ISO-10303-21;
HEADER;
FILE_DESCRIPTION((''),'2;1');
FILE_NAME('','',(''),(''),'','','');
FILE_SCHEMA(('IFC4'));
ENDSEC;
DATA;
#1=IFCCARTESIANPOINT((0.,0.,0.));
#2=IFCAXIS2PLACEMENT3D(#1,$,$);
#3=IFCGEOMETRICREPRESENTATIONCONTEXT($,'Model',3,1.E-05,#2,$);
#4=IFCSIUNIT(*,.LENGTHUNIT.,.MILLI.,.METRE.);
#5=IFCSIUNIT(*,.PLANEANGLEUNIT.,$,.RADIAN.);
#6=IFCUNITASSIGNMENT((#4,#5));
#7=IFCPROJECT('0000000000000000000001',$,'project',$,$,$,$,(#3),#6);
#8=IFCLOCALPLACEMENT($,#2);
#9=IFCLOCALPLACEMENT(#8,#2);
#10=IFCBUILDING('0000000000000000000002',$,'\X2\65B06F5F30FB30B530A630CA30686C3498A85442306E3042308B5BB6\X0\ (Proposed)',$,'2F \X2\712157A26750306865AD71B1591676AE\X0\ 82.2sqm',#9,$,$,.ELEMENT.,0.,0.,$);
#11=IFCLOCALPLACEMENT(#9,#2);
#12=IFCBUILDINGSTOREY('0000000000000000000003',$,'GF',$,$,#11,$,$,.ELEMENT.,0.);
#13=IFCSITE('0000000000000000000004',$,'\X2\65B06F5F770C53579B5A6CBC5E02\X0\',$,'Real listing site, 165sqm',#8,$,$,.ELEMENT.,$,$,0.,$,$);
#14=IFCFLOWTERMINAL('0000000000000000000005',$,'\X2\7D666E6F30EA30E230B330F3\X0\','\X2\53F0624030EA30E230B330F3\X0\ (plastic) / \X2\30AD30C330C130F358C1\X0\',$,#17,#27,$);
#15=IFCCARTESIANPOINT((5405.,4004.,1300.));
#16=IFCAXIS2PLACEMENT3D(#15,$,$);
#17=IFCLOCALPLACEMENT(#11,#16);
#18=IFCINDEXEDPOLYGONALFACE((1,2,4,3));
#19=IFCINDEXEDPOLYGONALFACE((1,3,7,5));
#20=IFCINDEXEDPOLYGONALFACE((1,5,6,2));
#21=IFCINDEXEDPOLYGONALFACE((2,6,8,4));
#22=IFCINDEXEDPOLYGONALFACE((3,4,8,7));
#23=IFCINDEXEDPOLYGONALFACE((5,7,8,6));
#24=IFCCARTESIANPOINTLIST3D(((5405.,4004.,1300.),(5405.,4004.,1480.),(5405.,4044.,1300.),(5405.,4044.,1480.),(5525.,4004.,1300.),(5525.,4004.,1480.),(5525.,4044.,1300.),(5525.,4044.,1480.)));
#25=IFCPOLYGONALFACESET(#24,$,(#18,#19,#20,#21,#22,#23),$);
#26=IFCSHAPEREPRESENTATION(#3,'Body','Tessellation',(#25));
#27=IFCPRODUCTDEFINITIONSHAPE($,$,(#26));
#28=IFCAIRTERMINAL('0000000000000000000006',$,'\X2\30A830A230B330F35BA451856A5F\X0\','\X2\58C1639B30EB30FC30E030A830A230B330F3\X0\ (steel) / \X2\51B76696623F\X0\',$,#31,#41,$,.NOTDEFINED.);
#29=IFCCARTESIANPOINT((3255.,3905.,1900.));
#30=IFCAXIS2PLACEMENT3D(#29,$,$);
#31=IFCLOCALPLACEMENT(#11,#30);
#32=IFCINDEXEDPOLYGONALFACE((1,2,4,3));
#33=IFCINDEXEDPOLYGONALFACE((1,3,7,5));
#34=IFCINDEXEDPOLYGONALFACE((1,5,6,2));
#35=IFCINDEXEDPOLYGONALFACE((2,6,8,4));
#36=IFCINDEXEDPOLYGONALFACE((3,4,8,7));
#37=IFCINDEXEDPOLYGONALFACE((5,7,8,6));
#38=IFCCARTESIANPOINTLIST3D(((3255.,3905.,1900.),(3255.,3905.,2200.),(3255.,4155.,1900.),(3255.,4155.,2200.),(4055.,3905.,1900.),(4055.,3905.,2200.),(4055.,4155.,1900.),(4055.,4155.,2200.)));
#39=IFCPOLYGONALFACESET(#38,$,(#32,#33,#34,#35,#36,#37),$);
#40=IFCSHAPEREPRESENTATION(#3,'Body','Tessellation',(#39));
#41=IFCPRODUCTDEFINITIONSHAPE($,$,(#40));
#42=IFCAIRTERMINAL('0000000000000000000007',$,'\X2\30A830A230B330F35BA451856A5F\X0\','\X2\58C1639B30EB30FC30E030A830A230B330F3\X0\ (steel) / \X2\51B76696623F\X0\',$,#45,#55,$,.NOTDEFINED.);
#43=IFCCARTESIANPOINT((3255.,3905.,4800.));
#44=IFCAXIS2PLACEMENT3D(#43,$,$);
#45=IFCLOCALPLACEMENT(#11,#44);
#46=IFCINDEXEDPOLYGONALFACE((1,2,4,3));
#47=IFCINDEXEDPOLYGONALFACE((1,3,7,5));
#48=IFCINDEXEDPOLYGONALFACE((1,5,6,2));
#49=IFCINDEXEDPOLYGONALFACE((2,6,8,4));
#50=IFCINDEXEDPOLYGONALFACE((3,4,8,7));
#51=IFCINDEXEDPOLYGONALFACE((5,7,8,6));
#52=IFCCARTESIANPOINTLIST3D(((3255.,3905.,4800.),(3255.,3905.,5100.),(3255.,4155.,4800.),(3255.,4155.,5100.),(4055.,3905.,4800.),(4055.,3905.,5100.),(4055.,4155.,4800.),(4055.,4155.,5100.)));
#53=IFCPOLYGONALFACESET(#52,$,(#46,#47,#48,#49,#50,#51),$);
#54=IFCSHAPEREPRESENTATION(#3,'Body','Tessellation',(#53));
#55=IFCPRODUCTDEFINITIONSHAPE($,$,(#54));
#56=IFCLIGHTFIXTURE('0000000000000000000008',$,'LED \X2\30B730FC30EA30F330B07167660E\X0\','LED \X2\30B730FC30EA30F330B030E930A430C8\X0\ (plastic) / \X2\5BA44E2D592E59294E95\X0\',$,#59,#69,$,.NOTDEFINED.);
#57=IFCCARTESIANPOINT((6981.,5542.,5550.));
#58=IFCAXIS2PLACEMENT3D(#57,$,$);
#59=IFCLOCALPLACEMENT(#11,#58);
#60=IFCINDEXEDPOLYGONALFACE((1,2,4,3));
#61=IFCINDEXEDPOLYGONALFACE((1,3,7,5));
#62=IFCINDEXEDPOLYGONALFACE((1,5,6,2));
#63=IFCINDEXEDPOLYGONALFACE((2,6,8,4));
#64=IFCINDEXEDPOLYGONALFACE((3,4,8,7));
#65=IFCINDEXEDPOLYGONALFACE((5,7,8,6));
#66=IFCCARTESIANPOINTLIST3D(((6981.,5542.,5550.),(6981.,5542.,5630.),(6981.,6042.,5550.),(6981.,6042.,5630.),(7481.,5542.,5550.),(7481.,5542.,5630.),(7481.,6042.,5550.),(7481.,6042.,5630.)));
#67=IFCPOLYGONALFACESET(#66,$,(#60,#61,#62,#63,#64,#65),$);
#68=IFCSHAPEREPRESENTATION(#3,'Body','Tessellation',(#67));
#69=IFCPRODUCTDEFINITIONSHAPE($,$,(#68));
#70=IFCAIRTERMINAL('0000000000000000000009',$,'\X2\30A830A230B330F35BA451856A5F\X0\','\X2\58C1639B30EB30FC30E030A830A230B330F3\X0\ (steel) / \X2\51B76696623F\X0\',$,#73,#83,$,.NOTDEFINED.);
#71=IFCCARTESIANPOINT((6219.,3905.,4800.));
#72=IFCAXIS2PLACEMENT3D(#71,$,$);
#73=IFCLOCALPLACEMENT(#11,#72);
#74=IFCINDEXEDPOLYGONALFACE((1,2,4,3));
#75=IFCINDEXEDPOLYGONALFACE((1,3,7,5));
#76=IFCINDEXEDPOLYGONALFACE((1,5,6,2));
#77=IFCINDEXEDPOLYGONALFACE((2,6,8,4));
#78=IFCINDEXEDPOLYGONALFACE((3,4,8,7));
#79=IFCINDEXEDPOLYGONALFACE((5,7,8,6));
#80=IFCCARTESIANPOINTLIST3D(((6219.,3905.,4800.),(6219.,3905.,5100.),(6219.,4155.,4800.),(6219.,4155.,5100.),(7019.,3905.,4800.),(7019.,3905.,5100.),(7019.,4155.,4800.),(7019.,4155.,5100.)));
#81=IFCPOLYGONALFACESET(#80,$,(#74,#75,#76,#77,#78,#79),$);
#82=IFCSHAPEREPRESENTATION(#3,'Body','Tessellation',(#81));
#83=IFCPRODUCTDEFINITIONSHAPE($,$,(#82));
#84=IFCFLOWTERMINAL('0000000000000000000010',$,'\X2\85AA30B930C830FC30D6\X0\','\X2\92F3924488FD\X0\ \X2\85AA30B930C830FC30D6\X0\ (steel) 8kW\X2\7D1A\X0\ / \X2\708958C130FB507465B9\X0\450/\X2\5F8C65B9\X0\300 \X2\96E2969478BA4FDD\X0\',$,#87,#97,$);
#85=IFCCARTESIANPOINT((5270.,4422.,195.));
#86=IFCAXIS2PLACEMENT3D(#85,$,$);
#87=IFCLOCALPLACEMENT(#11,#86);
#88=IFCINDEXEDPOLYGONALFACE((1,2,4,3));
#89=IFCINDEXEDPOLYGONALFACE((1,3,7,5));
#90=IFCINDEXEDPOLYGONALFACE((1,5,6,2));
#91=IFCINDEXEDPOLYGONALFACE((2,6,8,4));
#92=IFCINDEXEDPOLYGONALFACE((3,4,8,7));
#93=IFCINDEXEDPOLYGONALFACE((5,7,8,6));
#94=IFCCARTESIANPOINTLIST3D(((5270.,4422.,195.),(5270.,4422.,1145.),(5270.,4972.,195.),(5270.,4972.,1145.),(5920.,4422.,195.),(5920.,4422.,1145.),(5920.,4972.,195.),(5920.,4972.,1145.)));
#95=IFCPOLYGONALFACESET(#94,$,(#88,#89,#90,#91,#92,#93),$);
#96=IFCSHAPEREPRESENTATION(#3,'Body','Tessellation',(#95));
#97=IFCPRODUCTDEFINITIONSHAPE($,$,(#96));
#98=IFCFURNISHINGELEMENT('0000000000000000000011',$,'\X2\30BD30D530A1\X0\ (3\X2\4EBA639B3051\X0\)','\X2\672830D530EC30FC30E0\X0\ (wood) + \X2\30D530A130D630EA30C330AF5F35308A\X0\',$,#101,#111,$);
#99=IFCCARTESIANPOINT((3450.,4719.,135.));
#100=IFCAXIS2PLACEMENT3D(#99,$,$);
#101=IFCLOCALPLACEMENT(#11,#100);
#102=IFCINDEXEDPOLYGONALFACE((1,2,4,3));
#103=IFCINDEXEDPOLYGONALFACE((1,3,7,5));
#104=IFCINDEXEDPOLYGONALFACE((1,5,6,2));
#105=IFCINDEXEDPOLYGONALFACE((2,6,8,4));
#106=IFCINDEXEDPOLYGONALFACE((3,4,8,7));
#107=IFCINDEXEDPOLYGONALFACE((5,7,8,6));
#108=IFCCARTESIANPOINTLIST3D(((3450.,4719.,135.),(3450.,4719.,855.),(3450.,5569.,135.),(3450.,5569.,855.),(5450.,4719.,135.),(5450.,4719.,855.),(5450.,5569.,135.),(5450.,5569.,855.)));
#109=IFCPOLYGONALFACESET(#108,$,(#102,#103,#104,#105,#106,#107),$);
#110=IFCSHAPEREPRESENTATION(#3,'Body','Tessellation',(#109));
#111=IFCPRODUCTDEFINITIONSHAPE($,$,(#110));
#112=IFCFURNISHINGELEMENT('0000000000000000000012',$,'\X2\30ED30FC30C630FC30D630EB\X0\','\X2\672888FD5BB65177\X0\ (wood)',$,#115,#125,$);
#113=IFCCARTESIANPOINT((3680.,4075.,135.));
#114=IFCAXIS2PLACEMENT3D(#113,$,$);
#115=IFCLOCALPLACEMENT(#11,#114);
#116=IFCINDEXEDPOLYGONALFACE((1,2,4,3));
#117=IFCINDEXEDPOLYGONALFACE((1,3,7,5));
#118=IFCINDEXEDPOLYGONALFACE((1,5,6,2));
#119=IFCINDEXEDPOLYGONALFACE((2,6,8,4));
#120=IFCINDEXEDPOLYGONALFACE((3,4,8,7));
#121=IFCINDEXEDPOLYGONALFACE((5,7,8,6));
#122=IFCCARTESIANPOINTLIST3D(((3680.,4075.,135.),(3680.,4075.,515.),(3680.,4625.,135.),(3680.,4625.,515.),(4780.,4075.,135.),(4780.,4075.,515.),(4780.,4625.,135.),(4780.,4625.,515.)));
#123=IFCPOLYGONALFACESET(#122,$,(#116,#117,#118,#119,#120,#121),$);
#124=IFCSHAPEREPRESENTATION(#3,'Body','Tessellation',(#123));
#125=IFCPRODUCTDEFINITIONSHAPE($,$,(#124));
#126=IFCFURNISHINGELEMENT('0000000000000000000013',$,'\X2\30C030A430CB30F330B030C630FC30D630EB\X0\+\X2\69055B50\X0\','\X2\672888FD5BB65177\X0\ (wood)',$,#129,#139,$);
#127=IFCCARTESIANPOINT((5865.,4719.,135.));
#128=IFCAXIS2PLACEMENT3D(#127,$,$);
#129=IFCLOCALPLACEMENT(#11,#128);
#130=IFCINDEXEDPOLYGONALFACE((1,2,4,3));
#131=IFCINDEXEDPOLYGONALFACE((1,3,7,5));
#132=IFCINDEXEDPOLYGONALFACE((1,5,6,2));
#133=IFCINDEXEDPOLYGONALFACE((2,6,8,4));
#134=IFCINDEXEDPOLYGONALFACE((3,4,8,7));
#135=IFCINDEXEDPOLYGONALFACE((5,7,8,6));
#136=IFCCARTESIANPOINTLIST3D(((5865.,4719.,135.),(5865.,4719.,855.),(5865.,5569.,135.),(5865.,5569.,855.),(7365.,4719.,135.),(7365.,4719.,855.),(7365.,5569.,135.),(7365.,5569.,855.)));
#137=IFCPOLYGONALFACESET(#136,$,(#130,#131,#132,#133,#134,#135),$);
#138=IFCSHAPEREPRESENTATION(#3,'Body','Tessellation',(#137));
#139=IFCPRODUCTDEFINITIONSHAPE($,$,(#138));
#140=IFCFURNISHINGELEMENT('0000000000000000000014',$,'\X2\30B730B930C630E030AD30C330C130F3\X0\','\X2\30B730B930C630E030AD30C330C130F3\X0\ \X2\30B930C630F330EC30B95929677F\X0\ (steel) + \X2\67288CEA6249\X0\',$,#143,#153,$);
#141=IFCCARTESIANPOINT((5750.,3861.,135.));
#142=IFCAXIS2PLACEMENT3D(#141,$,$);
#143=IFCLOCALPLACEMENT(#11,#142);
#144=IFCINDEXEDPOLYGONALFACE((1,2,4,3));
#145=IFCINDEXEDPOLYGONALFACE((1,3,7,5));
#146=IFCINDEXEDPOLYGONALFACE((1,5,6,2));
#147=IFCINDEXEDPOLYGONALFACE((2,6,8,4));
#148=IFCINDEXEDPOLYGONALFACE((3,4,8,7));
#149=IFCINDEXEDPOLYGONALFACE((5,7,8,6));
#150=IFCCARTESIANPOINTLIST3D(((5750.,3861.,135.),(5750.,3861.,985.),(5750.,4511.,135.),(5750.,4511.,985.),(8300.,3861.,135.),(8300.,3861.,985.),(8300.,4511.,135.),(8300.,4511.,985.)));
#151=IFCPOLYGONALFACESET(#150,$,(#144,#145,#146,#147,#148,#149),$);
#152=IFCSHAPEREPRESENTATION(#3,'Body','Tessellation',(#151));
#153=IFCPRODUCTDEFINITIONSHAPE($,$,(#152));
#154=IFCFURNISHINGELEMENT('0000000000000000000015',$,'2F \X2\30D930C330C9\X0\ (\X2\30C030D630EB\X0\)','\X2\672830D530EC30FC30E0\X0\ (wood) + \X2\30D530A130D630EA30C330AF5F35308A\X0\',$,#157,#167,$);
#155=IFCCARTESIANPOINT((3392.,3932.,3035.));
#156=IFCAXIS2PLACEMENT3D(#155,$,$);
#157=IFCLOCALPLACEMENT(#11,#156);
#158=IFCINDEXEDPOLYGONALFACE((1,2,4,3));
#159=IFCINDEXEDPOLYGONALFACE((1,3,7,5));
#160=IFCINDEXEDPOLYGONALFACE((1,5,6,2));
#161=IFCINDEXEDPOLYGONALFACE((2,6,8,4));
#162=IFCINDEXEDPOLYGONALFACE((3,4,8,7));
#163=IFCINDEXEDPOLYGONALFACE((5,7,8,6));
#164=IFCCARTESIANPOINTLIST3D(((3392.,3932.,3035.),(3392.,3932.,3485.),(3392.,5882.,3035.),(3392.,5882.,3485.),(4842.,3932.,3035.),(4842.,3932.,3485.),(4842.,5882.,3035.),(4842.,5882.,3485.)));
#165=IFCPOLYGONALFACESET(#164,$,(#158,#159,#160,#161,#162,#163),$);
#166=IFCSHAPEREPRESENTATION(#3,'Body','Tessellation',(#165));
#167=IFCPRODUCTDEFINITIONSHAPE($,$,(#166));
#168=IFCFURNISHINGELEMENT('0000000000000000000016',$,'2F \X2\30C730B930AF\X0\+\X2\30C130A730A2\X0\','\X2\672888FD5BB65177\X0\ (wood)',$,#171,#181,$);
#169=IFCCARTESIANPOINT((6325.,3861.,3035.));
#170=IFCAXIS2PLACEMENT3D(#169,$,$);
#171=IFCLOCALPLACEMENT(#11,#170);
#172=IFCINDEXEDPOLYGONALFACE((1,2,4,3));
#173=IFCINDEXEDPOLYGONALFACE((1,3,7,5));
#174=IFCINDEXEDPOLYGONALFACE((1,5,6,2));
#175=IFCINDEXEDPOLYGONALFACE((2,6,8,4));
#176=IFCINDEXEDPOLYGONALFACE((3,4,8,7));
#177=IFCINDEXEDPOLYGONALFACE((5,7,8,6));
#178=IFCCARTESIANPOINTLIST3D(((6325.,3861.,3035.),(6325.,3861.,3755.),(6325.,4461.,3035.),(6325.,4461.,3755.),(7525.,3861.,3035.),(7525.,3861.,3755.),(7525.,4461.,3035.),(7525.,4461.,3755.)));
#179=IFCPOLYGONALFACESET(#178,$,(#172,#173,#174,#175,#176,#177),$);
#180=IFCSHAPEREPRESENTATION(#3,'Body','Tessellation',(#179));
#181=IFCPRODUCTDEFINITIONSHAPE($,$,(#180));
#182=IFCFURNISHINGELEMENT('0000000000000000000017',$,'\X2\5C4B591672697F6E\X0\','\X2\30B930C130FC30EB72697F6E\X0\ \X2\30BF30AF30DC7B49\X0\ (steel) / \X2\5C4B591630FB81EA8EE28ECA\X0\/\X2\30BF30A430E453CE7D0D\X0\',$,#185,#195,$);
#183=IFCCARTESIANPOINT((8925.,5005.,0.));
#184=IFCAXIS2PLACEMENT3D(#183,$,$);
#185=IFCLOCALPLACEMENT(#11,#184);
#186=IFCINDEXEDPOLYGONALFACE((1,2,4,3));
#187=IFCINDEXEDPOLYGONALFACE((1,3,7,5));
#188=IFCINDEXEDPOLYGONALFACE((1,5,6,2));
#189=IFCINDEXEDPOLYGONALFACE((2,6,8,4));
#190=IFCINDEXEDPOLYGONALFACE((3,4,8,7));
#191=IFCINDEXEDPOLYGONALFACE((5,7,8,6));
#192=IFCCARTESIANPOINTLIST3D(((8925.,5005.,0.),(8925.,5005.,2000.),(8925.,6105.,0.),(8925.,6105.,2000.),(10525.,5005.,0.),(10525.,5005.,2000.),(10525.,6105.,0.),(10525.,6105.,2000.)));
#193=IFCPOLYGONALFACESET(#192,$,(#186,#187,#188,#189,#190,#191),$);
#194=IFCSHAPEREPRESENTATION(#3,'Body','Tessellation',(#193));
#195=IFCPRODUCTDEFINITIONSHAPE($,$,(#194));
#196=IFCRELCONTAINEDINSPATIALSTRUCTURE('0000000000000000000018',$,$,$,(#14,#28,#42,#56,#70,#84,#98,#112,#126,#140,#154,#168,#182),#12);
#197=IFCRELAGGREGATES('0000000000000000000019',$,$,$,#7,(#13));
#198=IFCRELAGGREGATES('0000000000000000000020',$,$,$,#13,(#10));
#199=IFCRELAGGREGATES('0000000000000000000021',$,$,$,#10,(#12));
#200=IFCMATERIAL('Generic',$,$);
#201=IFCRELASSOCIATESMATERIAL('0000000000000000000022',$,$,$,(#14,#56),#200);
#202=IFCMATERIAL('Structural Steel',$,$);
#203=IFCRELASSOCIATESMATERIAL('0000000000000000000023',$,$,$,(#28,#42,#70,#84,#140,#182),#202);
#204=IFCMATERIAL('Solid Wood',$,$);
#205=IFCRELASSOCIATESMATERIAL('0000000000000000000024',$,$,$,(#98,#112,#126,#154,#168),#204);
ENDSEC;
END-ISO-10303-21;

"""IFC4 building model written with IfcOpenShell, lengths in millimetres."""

from ifc_helpers import new_model, si_unit, frame, frame_2d, origin, place, context, project, spatial, rectangle, extrude, material, element, save


model = new_model("IFC4")

# Units and contexts
model_context = context("Model", 3, precision=1e-05, world=origin())
ifc_project = project(units=[si_unit("LENGTHUNIT", "METRE", prefix="MILLI"), si_unit("PLANEANGLEUNIT", "RADIAN")], contexts=[model_context])

# Site, building, storey
site_placement = place(None, origin())
site = spatial("IfcSite", under=ifc_project, at=site_placement, Name="新潟県南魚沼市", ObjectType="Real listing site, 165sqm", CompositionType="ELEMENT", RefElevation=0.0)
building_placement = place(site_placement, origin())
building = spatial("IfcBuilding", under=site, at=building_placement, Name="新潟・サウナと水風呂のある家 (Proposed)", ObjectType="2F 無垢材と断熱外皮 82.2sqm", CompositionType="ELEMENT", ElevationOfRefHeight=0.0, ElevationOfTerrain=0.0)
storey_placement = place(building_placement, origin())
storey = spatial("IfcBuildingStorey", under=building, at=storey_placement, Name="GF", CompositionType="ELEMENT", Elevation=0.0)

# Shared definitions
ifc_material_1 = material(Name="Solid Wood")

# Shared definitions
ifc_material_2 = material(Name="Structural Steel")

# Shared definitions
ifc_material_3 = material(Name="Generic")

# Flow terminal
flow_terminal_1_placement = place(storey_placement, frame((5405.0, 4004.0, 1300.0)))
element("IfcFlowTerminal", 1, at=flow_terminal_1_placement, inside=storey, material=ifc_material_3, Name="給湯リモコン", Description="台所リモコン (plastic) / キッチン壁", context=model_context, shape_type="SweptSolid", body=[
    extrude(rectangle(XDim=120.0, YDim=40.0, at=frame_2d((60.0, 20.0))), frame((5405.0, 4004.0, 1300.0)), (0.0, 0.0, 1.0), 180.0),
])

# Air terminals
air_terminal_1_placement = place(storey_placement, frame((3255.0, 3905.0, 1900.0)))
element("IfcAirTerminal", 2, at=air_terminal_1_placement, inside=storey, material=ifc_material_2, Name="エアコン室内機", Description="壁掛ルームエアコン (steel) / 冷暖房", PredefinedType="NOTDEFINED", context=model_context, shape_type="SweptSolid", body=[
    extrude(rectangle(XDim=800.0, YDim=250.0, at=frame_2d((400.0, 125.0))), frame((3255.0, 3905.0, 1900.0)), (0.0, 0.0, 1.0), 300.0),
])
air_terminal_2_placement = place(storey_placement, frame((3255.0, 3905.0, 4800.0)))
element("IfcAirTerminal", 3, at=air_terminal_2_placement, inside=storey, material=ifc_material_2, Name="エアコン室内機", Description="壁掛ルームエアコン (steel) / 冷暖房", PredefinedType="NOTDEFINED", context=model_context, shape_type="SweptSolid", body=[
    extrude(rectangle(XDim=800.0, YDim=250.0, at=frame_2d((400.0, 125.0))), frame((3255.0, 3905.0, 4800.0)), (0.0, 0.0, 1.0), 300.0),
])

# Light fixture
light_fixture_placement = place(storey_placement, frame((6981.0, 5542.0, 5550.0)))
element("IfcLightFixture", 4, at=light_fixture_placement, inside=storey, material=ifc_material_3, Name="LED シーリング照明", Description="LED シーリングライト (plastic) / 室中央天井", PredefinedType="NOTDEFINED", context=model_context, shape_type="SweptSolid", body=[
    extrude(rectangle(XDim=500.0, YDim=500.0, at=frame_2d((250.0, 250.0))), frame((6981.0, 5542.0, 5550.0)), (0.0, 0.0, 1.0), 80.0),
])

# Air terminal
air_terminal_3_placement = place(storey_placement, frame((6219.0, 3905.0, 4800.0)))
element("IfcAirTerminal", 5, at=air_terminal_3_placement, inside=storey, material=ifc_material_2, Name="エアコン室内機", Description="壁掛ルームエアコン (steel) / 冷暖房", PredefinedType="NOTDEFINED", context=model_context, shape_type="SweptSolid", body=[
    extrude(rectangle(XDim=800.0, YDim=250.0, at=frame_2d((400.0, 125.0))), frame((6219.0, 3905.0, 4800.0)), (0.0, 0.0, 1.0), 300.0),
])

# Flow terminal
flow_terminal_2_placement = place(storey_placement, frame((5270.0, 4422.0, 195.0)))
element("IfcFlowTerminal", 6, at=flow_terminal_2_placement, inside=storey, material=ifc_material_2, Name="薪ストーブ", Description="鋳鉄製 薪ストーブ (steel) 8kW級 / 炉壁・側方450/後方300 離隔確保", context=model_context, shape_type="SweptSolid", body=[
    extrude(rectangle(XDim=650.0, YDim=550.0, at=frame_2d((325.0, 275.0))), frame((5270.0, 4422.0, 195.0)), (0.0, 0.0, 1.0), 950.0),
])

# Furnishing elements
furnishing_1_placement = place(storey_placement, frame((3450.0, 4719.0, 135.0)))
element("IfcFurnishingElement", 7, at=furnishing_1_placement, inside=storey, material=ifc_material_1, Name="ソファ (3人掛け)", Description="木フレーム (wood) + ファブリック張り", context=model_context, shape_type="SweptSolid", body=[
    extrude(rectangle(XDim=2000.0, YDim=850.0, at=frame_2d((1000.0, 425.0))), frame((3450.0, 4719.0, 135.0)), (0.0, 0.0, 1.0), 720.0),
])
furnishing_2_placement = place(storey_placement, frame((3680.0, 4075.0, 135.0)))
element("IfcFurnishingElement", 8, at=furnishing_2_placement, inside=storey, material=ifc_material_1, Name="ローテーブル", Description="木製家具 (wood)", context=model_context, shape_type="SweptSolid", body=[
    extrude(rectangle(XDim=1100.0, YDim=550.0, at=frame_2d((550.0, 275.0))), frame((3680.0, 4075.0, 135.0)), (0.0, 0.0, 1.0), 380.0),
])
furnishing_3_placement = place(storey_placement, frame((5865.0, 4719.0, 135.0)))
element("IfcFurnishingElement", 9, at=furnishing_3_placement, inside=storey, material=ifc_material_1, Name="ダイニングテーブル+椅子", Description="木製家具 (wood)", context=model_context, shape_type="SweptSolid", body=[
    extrude(rectangle(XDim=1500.0, YDim=850.0, at=frame_2d((750.0, 425.0))), frame((5865.0, 4719.0, 135.0)), (0.0, 0.0, 1.0), 720.0),
])
furnishing_4_placement = place(storey_placement, frame((5750.0, 3861.0, 135.0)))
element("IfcFurnishingElement", 10, at=furnishing_4_placement, inside=storey, material=ifc_material_2, Name="システムキッチン", Description="システムキッチン ステンレス天板 (steel) + 木質扉", context=model_context, shape_type="SweptSolid", body=[
    extrude(rectangle(XDim=2550.0, YDim=650.0, at=frame_2d((1275.0, 325.0))), frame((5750.0, 3861.0, 135.0)), (0.0, 0.0, 1.0), 850.0),
])
furnishing_5_placement = place(storey_placement, frame((3392.0, 3932.0, 3035.0)))
element("IfcFurnishingElement", 11, at=furnishing_5_placement, inside=storey, material=ifc_material_1, Name="2F ベッド (ダブル)", Description="木フレーム (wood) + ファブリック張り", context=model_context, shape_type="SweptSolid", body=[
    extrude(rectangle(XDim=1450.0, YDim=1950.0, at=frame_2d((725.0, 975.0))), frame((3392.0, 3932.0, 3035.0)), (0.0, 0.0, 1.0), 450.0),
])
furnishing_6_placement = place(storey_placement, frame((6325.0, 3861.0, 3035.0)))
element("IfcFurnishingElement", 12, at=furnishing_6_placement, inside=storey, material=ifc_material_1, Name="2F デスク+チェア", Description="木製家具 (wood)", context=model_context, shape_type="SweptSolid", body=[
    extrude(rectangle(XDim=1200.0, YDim=600.0, at=frame_2d((600.0, 300.0))), frame((6325.0, 3861.0, 3035.0)), (0.0, 0.0, 1.0), 720.0),
])
furnishing_7_placement = place(storey_placement, frame((8925.0, 5005.0, 0.0)))
element("IfcFurnishingElement", 13, at=furnishing_7_placement, inside=storey, material=ifc_material_2, Name="屋外物置", Description="スチール物置 タクボ等 (steel) / 屋外・自転車/タイヤ収納", context=model_context, shape_type="SweptSolid", body=[
    extrude(rectangle(XDim=1600.0, YDim=1100.0, at=frame_2d((800.0, 550.0))), frame((8925.0, 5005.0, 0.0)), (0.0, 0.0, 1.0), 2000.0),
])

save(model, "model.ifc")
